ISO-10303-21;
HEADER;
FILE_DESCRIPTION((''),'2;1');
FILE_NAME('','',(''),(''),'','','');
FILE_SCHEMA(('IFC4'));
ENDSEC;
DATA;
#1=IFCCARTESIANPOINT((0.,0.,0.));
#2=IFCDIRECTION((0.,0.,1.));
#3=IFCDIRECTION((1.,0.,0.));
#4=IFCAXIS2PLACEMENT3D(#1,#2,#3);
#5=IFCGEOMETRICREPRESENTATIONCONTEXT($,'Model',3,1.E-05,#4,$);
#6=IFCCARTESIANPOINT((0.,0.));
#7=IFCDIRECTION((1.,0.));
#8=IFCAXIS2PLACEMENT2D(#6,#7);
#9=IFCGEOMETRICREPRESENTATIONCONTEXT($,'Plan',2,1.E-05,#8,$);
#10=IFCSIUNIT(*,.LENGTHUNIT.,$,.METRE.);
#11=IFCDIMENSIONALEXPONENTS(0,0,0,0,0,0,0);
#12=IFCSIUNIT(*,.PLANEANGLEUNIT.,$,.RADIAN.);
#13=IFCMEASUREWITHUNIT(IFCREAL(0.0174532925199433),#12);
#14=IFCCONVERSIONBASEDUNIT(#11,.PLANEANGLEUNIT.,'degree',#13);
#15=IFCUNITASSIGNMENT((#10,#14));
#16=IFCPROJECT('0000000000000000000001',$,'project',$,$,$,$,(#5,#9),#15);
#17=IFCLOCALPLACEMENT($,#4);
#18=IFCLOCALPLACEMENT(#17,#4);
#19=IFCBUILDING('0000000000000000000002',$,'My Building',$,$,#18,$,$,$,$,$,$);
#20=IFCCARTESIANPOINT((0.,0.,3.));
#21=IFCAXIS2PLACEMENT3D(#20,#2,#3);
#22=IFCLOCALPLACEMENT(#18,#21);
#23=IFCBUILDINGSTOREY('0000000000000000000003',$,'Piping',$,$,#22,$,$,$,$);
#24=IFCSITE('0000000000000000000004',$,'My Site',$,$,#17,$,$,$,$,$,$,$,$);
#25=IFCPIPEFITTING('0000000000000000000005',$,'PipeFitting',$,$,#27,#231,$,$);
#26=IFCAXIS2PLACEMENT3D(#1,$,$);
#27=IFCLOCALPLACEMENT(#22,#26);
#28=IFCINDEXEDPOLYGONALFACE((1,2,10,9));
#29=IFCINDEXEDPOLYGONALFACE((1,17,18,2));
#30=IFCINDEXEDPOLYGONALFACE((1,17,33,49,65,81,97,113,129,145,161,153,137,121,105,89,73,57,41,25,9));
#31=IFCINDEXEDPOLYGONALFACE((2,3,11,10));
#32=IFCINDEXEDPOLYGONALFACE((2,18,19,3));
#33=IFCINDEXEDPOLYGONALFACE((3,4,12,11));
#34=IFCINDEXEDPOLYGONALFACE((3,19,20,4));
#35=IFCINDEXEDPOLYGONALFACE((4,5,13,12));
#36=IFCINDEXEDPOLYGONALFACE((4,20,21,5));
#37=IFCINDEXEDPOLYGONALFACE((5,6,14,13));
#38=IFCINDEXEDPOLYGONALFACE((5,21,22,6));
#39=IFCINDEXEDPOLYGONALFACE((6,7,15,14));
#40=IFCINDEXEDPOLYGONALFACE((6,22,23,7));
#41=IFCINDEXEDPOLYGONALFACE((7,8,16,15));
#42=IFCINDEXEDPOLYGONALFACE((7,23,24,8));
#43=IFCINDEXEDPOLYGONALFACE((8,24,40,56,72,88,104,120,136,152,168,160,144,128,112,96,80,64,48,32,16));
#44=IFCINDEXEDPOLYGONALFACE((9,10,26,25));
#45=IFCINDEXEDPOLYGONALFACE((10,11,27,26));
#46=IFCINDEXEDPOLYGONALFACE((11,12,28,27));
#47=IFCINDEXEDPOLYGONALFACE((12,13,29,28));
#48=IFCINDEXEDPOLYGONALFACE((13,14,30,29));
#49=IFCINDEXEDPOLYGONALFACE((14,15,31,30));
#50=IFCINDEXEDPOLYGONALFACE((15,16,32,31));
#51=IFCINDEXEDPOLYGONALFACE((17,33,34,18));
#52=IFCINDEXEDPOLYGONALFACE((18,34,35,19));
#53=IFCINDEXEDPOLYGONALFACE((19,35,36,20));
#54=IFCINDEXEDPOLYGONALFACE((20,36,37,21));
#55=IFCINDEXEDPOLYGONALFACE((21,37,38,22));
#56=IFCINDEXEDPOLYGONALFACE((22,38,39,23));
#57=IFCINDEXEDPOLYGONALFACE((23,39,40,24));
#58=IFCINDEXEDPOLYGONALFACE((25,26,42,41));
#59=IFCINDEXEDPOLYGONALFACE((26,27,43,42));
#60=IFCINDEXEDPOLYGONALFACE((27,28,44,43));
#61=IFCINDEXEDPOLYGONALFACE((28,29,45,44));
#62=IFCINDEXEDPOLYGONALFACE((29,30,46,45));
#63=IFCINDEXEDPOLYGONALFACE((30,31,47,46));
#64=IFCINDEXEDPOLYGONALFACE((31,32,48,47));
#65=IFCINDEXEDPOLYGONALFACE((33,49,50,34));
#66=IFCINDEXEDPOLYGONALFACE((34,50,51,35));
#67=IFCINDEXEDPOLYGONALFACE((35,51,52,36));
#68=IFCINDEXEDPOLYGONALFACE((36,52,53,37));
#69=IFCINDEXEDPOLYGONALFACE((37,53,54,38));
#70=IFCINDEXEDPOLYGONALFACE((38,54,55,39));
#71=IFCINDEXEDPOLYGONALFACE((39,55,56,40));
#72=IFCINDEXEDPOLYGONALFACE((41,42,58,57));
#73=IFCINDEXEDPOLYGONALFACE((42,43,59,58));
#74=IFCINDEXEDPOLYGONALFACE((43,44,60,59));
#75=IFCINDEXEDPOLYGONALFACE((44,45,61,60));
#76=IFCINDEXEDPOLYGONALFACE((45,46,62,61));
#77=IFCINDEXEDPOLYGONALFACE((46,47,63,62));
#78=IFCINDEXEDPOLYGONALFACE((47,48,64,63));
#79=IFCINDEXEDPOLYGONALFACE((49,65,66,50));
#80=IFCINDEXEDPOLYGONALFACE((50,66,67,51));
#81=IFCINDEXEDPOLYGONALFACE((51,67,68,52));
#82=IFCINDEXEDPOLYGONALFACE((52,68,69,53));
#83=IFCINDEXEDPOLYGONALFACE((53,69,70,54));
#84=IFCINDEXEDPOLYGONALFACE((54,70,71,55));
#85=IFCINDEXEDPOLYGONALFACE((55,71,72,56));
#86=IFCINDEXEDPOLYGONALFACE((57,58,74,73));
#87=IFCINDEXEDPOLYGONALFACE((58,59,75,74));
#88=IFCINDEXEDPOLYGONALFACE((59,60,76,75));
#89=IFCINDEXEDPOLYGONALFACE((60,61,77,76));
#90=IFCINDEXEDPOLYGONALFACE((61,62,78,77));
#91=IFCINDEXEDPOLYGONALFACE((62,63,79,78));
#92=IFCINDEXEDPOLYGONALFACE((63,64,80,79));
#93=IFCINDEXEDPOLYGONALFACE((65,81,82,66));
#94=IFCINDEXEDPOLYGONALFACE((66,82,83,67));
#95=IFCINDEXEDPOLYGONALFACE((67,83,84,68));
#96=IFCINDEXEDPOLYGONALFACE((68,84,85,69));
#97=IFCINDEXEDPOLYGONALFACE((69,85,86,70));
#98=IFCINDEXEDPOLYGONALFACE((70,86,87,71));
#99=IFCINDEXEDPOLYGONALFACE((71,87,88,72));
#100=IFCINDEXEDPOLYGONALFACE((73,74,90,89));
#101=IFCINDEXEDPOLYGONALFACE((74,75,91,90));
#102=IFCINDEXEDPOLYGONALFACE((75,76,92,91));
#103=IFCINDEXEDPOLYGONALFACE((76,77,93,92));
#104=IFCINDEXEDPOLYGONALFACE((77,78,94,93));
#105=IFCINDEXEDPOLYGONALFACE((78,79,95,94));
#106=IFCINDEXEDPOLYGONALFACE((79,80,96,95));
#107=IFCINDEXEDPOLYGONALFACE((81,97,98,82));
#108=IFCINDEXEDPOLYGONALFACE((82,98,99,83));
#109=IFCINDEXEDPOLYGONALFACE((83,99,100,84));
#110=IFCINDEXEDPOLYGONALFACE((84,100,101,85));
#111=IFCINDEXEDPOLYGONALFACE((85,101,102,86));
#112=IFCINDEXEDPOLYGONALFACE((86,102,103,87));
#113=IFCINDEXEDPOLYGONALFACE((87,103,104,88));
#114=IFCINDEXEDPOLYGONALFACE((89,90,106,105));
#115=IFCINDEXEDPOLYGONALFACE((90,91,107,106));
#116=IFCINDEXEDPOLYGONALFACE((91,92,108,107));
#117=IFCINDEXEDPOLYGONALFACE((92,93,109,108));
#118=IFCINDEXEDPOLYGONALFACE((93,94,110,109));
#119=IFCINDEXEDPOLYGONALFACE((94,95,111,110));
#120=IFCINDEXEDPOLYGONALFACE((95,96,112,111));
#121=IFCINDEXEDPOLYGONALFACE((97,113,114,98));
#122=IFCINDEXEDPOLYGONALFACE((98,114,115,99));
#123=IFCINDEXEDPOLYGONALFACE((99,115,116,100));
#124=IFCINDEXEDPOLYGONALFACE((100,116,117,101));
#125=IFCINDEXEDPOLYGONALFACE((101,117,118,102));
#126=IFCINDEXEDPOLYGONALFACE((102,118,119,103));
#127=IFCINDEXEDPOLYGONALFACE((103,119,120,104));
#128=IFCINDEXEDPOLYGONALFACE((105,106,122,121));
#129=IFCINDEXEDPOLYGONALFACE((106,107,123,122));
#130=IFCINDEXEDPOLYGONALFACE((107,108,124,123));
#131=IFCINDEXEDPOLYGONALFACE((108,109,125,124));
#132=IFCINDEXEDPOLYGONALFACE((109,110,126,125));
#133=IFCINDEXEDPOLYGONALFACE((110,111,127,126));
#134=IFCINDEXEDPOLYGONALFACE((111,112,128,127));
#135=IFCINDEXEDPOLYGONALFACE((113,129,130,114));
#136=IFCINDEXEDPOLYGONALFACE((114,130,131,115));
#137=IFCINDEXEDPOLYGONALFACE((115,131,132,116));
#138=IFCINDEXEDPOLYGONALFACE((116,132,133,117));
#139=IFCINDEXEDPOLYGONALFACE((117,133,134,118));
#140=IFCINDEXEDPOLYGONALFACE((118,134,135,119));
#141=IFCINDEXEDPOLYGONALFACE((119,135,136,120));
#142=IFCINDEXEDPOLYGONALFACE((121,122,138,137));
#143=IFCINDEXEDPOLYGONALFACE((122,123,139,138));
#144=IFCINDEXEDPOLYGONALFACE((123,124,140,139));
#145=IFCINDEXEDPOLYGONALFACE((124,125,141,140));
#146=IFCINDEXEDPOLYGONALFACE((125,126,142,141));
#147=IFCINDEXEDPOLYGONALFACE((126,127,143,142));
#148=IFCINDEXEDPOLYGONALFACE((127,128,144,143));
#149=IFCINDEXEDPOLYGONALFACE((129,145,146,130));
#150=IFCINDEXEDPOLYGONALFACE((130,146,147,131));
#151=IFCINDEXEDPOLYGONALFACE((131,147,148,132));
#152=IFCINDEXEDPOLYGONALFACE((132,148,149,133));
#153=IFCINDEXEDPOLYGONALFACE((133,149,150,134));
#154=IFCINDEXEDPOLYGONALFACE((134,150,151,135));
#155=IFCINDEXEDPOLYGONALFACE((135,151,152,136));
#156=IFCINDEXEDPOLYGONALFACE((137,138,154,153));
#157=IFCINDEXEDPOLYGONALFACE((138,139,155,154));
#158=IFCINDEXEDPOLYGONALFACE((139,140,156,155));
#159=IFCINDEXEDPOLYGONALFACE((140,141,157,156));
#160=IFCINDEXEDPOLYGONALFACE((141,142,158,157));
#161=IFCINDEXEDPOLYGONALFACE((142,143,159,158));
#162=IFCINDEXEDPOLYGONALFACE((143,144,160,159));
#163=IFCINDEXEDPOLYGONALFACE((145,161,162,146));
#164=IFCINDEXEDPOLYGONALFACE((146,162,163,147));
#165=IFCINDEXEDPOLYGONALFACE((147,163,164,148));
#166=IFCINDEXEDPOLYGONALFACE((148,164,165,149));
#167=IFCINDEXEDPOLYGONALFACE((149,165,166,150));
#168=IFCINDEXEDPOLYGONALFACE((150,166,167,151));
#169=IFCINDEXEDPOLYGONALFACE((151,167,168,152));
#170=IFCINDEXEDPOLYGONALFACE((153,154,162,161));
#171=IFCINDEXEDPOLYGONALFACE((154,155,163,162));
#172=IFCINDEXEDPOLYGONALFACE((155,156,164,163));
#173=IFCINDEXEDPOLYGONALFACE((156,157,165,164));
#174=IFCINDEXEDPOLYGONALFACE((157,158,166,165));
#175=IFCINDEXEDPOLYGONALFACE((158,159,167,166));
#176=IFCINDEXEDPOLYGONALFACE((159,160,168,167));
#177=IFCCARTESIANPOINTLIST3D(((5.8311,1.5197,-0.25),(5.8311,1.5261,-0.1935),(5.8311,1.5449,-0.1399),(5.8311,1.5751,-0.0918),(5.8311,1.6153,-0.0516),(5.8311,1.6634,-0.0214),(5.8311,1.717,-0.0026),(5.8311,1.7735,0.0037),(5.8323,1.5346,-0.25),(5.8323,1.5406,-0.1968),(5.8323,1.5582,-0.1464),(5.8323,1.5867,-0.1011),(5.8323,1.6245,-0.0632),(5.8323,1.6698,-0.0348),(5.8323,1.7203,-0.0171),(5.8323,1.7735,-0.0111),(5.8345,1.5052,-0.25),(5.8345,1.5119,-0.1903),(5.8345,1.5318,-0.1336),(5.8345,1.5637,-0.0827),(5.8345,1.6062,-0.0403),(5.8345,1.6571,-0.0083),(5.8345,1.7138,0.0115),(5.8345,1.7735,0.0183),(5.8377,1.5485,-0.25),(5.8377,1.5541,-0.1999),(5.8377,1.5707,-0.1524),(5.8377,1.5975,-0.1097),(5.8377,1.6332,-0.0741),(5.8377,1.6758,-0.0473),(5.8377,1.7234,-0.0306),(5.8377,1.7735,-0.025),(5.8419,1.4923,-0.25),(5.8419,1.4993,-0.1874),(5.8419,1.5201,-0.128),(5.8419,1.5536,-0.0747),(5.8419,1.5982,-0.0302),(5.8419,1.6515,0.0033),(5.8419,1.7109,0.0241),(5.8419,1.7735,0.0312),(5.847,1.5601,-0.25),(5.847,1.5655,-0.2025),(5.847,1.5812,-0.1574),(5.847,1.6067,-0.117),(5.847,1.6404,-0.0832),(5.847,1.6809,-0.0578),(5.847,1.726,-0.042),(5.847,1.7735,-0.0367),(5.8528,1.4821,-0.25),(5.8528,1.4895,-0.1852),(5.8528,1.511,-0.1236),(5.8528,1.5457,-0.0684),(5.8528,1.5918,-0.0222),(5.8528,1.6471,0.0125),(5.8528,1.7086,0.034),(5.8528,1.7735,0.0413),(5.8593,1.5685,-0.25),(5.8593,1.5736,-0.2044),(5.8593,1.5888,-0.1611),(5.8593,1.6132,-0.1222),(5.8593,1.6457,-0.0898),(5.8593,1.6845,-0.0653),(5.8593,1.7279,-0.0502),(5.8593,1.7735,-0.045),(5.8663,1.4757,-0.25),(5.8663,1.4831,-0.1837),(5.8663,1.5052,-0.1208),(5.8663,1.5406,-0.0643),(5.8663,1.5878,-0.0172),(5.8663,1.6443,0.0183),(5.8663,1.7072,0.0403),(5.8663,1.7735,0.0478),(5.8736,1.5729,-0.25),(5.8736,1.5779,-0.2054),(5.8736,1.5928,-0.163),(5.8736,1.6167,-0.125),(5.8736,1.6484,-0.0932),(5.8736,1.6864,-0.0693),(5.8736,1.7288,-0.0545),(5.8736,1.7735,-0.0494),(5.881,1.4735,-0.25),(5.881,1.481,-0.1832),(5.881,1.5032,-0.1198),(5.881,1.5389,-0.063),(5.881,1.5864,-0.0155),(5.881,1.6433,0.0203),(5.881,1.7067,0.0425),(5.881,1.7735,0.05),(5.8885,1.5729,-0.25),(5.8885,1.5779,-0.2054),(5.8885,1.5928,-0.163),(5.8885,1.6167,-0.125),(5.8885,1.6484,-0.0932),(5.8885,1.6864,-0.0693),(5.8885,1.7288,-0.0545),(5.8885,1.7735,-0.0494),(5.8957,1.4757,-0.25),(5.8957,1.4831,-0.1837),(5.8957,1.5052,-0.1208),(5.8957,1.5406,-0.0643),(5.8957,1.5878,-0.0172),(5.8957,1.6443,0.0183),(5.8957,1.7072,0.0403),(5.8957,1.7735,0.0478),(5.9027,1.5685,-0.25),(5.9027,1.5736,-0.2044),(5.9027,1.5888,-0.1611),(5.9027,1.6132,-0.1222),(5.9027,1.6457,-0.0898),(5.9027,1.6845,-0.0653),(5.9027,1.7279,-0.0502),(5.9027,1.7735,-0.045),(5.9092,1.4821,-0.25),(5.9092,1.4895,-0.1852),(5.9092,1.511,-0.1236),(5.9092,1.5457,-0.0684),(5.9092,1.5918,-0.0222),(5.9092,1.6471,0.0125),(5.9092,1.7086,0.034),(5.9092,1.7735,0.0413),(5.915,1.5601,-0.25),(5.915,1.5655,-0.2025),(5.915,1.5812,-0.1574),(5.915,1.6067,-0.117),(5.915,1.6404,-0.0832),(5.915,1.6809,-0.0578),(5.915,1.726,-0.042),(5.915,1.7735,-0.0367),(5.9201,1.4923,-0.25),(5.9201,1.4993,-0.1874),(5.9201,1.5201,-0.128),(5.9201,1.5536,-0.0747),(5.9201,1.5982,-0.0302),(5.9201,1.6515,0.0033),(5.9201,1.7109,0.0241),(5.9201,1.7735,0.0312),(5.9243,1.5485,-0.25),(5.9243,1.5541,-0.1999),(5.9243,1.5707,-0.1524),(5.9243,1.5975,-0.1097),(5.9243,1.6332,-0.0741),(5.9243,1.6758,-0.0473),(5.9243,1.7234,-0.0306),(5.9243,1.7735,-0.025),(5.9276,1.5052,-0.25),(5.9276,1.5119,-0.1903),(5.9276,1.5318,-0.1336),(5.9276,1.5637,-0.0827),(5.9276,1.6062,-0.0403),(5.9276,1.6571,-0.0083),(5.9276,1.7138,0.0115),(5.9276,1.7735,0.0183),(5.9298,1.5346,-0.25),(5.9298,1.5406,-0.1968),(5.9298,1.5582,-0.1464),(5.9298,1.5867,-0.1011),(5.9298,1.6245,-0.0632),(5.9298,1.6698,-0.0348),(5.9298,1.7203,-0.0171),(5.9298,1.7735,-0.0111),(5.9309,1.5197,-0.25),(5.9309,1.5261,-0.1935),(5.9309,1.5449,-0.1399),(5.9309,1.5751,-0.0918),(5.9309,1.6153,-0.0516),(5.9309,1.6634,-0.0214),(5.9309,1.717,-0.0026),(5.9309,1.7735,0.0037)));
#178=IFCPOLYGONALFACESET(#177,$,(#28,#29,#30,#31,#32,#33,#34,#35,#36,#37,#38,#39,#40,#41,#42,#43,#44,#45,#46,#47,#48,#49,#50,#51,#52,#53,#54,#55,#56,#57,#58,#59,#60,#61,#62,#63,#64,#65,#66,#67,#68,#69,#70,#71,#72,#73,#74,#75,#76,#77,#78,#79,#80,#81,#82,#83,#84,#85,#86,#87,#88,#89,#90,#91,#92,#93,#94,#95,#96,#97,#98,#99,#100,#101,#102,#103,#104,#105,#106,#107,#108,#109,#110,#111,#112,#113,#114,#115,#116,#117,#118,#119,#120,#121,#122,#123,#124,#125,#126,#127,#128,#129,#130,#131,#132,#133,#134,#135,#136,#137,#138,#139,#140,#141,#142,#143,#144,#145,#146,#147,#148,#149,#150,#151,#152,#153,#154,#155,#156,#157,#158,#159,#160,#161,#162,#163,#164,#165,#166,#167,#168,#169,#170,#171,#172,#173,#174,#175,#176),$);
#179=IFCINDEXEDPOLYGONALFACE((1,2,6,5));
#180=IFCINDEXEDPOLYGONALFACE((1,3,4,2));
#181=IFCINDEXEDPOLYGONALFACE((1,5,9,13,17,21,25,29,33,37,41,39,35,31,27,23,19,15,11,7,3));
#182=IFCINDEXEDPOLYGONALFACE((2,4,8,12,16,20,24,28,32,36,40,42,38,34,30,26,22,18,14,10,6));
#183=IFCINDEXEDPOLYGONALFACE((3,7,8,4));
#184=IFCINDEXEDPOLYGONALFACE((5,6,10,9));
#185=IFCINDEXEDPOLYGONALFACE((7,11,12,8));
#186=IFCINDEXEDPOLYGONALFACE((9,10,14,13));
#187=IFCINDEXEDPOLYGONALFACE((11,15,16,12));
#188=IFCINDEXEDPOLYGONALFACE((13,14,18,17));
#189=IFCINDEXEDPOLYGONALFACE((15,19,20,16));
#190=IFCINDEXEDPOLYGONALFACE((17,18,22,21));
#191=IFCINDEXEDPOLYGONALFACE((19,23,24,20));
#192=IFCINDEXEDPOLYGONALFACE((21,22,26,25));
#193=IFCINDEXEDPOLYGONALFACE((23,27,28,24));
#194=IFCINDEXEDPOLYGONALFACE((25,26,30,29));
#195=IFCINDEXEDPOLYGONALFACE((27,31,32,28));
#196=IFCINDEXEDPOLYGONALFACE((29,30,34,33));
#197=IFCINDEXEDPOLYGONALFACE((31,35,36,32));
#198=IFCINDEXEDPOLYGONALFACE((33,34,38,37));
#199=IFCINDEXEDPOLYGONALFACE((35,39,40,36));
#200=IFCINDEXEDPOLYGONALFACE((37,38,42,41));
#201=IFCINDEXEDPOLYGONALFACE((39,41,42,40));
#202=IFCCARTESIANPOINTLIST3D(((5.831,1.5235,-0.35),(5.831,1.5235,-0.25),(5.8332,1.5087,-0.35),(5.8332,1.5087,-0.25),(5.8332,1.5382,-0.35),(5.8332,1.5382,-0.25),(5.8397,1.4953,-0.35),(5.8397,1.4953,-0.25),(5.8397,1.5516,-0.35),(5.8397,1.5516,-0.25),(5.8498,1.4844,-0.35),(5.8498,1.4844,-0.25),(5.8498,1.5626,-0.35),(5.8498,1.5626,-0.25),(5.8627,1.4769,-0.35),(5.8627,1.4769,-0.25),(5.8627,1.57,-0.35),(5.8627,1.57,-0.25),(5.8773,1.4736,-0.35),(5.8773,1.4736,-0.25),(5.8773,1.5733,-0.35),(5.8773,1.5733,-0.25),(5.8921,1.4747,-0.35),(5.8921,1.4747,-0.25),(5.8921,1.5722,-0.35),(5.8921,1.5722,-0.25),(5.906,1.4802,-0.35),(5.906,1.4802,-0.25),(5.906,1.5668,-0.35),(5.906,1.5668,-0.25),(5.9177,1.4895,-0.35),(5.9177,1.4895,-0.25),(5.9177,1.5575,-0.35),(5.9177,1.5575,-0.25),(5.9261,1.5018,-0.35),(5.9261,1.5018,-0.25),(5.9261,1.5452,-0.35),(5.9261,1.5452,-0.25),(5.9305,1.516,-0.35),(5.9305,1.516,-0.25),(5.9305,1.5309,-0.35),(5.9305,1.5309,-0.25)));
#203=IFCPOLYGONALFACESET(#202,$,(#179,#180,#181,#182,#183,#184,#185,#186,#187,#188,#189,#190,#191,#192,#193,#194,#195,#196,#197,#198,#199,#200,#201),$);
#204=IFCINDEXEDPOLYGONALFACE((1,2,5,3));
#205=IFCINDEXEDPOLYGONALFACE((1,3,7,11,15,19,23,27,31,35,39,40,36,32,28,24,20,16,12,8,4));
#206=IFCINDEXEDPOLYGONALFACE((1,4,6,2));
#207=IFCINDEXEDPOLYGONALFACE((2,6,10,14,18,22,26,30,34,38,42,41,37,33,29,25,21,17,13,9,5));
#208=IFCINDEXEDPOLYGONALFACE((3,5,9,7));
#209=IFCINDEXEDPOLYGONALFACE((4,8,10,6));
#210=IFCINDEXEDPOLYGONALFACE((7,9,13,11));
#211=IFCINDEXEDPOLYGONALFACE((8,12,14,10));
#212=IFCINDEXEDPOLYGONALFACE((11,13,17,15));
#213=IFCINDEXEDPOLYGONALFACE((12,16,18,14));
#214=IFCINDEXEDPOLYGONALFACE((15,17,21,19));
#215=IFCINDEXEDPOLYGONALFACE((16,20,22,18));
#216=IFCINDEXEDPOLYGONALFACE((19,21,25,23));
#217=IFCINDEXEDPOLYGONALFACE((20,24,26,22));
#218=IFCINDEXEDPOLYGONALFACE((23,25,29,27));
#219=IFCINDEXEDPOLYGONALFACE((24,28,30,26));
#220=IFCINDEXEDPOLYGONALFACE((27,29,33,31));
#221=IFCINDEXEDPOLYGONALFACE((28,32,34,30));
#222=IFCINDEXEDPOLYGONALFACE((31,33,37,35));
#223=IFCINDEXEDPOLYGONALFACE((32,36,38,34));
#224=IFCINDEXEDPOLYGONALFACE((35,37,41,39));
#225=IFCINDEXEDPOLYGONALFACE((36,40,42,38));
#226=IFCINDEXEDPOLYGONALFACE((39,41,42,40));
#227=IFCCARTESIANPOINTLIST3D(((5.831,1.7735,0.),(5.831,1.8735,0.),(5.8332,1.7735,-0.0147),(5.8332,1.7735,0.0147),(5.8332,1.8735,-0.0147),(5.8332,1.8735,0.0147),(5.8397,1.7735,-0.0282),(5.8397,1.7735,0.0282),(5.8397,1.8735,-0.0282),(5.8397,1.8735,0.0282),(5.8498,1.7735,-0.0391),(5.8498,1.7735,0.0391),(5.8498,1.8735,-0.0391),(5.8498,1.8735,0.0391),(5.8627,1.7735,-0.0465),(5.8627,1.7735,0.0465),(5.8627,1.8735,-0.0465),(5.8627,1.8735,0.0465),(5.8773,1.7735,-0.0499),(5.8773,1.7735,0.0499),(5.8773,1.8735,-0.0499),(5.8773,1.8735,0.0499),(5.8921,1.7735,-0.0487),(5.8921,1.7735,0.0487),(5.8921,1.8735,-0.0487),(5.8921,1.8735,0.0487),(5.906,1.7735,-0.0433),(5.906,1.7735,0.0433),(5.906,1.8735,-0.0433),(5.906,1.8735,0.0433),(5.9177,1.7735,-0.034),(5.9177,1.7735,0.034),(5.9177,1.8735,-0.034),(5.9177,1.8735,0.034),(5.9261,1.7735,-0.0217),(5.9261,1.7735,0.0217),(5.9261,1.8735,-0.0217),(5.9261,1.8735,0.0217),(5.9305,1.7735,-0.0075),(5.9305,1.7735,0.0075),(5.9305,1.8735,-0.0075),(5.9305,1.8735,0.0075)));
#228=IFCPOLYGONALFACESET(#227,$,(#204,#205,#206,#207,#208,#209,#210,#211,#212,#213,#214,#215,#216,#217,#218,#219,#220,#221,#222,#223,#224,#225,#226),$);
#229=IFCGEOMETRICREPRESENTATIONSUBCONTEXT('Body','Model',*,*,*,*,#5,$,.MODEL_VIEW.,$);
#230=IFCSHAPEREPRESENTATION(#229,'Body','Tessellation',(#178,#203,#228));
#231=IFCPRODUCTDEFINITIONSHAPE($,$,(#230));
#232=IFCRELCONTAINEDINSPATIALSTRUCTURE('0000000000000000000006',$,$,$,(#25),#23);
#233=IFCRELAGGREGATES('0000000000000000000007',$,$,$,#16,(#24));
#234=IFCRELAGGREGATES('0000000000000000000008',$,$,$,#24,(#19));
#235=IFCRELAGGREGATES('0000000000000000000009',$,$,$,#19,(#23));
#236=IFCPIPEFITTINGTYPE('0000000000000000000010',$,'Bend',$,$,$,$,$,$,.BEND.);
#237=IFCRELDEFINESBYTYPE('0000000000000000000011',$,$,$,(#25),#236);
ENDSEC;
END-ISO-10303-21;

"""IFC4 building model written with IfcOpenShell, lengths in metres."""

from ifc_helpers import new_model, entity, si_unit, converted_unit, frame, origin_with_axes, origin_2d_with_axis, place, context, subcontext, project, spatial, line, indexed_curve, circle, outline, extrude, source, transform, mapped, type_object, type_shapes, element, save


model = new_model("IFC4")

# Units and contexts
model_context = context("Model", 3, precision=1e-05, world=origin_with_axes())
plan_context = context("Plan", 2, precision=1e-05, world=origin_2d_with_axis())
body_context = subcontext(model_context, "Body", "Model", "MODEL_VIEW")
ifc_project = project(units=[si_unit("LENGTHUNIT", "METRE"), converted_unit("PLANEANGLEUNIT", "degree", entity("IfcReal", 0.0174532925199433), si_unit("PLANEANGLEUNIT", "RADIAN"), dimensions=[0, 0, 0, 0, 0, 0, 0])], contexts=[model_context, plan_context])

# Site, building, storey
site_placement = place(None, origin_with_axes())
site = spatial("IfcSite", under=ifc_project, at=site_placement, Name="My Site")
building_placement = place(site_placement, origin_with_axes())
building = spatial("IfcBuilding", under=site, at=building_placement, Name="My Building")
storey_placement = place(building_placement, frame((0.0, 0.0, 3.0), z_axis=(0.0, 0.0, 1.0), x_axis=(1.0, 0.0, 0.0)))
storey = spatial("IfcBuildingStorey", under=building, at=storey_placement, Name="Piping")

# Pipe fitting, opening
pipe_fitting_type = type_object("IfcPipeFittingType", Name="Bend", PredefinedType="BEND")
shared_shape = source(origin_with_axes(), body_context, "Body", "SolidModel", [
    entity("IfcSweptDiskSolid", entity("IfcIndexedPolyCurve", entity("IfcCartesianPointList3D", [[0.0, 0.0, -0.1], [0.0, 0.0732, -0.2768], [0.0, 0.25, -0.35]]), [entity("IfcArcIndex", [1, 2, 3])]), 0.05),
    extrude(circle(Radius=0.05), origin_with_axes(), (0.0, 0.0, -1.0), 0.1),
    extrude(circle(Radius=0.05), frame((0.0, 0.25, -0.35), z_axis=(0.0, 1.0, 0.0), x_axis=(1.0, 0.0, 0.0)), (0.0, 0.0, 1.0), 0.1),
])
type_shapes(pipe_fitting_type, [shared_shape])
pipe_fitting_1_placement = place(storey_placement, frame((5.881, 1.5235, -0.35), z_axis=(0.0, 0.0, -1.0), x_axis=(-1.0, 0.0, 0.0)))
pipe_fitting_1 = element("IfcPipeFitting", 1, at=pipe_fitting_1_placement, inside=storey, type_object=pipe_fitting_type, Name="PipeFitting", context=body_context, shape_type="MappedRepresentation", body=[
    mapped(shared_shape, transform((0.0, 0.0, 0.0), x_axis=(1.0, 0.0, 0.0), y_axis=(0.0, 1.0, 0.0), z_axis=(0.0, 0.0, 1.0), scale=1.0)),
])
opening_1_placement = place(pipe_fitting_1_placement, frame((1.9673, -1.5235, 2.65), z_axis=(0.0, 0.0, -1.0), x_axis=(-1.0, 0.0, 0.0)))
element("IfcOpeningElement", 2, at=opening_1_placement, cuts=pipe_fitting_1, PredefinedType="OPENING", context=body_context, shape_type="SweptSolid", body=[
    extrude(outline(indexed_curve([(0.0, 0.0), (0.5, 0.0), (0.5, 0.5), (0.0, 0.5)], segments=[line(1, 2, 3, 4, 1)])), origin_with_axes(), (0.0, 0.0, 1.0), 0.5),
])

save(model, "model.ifc")
